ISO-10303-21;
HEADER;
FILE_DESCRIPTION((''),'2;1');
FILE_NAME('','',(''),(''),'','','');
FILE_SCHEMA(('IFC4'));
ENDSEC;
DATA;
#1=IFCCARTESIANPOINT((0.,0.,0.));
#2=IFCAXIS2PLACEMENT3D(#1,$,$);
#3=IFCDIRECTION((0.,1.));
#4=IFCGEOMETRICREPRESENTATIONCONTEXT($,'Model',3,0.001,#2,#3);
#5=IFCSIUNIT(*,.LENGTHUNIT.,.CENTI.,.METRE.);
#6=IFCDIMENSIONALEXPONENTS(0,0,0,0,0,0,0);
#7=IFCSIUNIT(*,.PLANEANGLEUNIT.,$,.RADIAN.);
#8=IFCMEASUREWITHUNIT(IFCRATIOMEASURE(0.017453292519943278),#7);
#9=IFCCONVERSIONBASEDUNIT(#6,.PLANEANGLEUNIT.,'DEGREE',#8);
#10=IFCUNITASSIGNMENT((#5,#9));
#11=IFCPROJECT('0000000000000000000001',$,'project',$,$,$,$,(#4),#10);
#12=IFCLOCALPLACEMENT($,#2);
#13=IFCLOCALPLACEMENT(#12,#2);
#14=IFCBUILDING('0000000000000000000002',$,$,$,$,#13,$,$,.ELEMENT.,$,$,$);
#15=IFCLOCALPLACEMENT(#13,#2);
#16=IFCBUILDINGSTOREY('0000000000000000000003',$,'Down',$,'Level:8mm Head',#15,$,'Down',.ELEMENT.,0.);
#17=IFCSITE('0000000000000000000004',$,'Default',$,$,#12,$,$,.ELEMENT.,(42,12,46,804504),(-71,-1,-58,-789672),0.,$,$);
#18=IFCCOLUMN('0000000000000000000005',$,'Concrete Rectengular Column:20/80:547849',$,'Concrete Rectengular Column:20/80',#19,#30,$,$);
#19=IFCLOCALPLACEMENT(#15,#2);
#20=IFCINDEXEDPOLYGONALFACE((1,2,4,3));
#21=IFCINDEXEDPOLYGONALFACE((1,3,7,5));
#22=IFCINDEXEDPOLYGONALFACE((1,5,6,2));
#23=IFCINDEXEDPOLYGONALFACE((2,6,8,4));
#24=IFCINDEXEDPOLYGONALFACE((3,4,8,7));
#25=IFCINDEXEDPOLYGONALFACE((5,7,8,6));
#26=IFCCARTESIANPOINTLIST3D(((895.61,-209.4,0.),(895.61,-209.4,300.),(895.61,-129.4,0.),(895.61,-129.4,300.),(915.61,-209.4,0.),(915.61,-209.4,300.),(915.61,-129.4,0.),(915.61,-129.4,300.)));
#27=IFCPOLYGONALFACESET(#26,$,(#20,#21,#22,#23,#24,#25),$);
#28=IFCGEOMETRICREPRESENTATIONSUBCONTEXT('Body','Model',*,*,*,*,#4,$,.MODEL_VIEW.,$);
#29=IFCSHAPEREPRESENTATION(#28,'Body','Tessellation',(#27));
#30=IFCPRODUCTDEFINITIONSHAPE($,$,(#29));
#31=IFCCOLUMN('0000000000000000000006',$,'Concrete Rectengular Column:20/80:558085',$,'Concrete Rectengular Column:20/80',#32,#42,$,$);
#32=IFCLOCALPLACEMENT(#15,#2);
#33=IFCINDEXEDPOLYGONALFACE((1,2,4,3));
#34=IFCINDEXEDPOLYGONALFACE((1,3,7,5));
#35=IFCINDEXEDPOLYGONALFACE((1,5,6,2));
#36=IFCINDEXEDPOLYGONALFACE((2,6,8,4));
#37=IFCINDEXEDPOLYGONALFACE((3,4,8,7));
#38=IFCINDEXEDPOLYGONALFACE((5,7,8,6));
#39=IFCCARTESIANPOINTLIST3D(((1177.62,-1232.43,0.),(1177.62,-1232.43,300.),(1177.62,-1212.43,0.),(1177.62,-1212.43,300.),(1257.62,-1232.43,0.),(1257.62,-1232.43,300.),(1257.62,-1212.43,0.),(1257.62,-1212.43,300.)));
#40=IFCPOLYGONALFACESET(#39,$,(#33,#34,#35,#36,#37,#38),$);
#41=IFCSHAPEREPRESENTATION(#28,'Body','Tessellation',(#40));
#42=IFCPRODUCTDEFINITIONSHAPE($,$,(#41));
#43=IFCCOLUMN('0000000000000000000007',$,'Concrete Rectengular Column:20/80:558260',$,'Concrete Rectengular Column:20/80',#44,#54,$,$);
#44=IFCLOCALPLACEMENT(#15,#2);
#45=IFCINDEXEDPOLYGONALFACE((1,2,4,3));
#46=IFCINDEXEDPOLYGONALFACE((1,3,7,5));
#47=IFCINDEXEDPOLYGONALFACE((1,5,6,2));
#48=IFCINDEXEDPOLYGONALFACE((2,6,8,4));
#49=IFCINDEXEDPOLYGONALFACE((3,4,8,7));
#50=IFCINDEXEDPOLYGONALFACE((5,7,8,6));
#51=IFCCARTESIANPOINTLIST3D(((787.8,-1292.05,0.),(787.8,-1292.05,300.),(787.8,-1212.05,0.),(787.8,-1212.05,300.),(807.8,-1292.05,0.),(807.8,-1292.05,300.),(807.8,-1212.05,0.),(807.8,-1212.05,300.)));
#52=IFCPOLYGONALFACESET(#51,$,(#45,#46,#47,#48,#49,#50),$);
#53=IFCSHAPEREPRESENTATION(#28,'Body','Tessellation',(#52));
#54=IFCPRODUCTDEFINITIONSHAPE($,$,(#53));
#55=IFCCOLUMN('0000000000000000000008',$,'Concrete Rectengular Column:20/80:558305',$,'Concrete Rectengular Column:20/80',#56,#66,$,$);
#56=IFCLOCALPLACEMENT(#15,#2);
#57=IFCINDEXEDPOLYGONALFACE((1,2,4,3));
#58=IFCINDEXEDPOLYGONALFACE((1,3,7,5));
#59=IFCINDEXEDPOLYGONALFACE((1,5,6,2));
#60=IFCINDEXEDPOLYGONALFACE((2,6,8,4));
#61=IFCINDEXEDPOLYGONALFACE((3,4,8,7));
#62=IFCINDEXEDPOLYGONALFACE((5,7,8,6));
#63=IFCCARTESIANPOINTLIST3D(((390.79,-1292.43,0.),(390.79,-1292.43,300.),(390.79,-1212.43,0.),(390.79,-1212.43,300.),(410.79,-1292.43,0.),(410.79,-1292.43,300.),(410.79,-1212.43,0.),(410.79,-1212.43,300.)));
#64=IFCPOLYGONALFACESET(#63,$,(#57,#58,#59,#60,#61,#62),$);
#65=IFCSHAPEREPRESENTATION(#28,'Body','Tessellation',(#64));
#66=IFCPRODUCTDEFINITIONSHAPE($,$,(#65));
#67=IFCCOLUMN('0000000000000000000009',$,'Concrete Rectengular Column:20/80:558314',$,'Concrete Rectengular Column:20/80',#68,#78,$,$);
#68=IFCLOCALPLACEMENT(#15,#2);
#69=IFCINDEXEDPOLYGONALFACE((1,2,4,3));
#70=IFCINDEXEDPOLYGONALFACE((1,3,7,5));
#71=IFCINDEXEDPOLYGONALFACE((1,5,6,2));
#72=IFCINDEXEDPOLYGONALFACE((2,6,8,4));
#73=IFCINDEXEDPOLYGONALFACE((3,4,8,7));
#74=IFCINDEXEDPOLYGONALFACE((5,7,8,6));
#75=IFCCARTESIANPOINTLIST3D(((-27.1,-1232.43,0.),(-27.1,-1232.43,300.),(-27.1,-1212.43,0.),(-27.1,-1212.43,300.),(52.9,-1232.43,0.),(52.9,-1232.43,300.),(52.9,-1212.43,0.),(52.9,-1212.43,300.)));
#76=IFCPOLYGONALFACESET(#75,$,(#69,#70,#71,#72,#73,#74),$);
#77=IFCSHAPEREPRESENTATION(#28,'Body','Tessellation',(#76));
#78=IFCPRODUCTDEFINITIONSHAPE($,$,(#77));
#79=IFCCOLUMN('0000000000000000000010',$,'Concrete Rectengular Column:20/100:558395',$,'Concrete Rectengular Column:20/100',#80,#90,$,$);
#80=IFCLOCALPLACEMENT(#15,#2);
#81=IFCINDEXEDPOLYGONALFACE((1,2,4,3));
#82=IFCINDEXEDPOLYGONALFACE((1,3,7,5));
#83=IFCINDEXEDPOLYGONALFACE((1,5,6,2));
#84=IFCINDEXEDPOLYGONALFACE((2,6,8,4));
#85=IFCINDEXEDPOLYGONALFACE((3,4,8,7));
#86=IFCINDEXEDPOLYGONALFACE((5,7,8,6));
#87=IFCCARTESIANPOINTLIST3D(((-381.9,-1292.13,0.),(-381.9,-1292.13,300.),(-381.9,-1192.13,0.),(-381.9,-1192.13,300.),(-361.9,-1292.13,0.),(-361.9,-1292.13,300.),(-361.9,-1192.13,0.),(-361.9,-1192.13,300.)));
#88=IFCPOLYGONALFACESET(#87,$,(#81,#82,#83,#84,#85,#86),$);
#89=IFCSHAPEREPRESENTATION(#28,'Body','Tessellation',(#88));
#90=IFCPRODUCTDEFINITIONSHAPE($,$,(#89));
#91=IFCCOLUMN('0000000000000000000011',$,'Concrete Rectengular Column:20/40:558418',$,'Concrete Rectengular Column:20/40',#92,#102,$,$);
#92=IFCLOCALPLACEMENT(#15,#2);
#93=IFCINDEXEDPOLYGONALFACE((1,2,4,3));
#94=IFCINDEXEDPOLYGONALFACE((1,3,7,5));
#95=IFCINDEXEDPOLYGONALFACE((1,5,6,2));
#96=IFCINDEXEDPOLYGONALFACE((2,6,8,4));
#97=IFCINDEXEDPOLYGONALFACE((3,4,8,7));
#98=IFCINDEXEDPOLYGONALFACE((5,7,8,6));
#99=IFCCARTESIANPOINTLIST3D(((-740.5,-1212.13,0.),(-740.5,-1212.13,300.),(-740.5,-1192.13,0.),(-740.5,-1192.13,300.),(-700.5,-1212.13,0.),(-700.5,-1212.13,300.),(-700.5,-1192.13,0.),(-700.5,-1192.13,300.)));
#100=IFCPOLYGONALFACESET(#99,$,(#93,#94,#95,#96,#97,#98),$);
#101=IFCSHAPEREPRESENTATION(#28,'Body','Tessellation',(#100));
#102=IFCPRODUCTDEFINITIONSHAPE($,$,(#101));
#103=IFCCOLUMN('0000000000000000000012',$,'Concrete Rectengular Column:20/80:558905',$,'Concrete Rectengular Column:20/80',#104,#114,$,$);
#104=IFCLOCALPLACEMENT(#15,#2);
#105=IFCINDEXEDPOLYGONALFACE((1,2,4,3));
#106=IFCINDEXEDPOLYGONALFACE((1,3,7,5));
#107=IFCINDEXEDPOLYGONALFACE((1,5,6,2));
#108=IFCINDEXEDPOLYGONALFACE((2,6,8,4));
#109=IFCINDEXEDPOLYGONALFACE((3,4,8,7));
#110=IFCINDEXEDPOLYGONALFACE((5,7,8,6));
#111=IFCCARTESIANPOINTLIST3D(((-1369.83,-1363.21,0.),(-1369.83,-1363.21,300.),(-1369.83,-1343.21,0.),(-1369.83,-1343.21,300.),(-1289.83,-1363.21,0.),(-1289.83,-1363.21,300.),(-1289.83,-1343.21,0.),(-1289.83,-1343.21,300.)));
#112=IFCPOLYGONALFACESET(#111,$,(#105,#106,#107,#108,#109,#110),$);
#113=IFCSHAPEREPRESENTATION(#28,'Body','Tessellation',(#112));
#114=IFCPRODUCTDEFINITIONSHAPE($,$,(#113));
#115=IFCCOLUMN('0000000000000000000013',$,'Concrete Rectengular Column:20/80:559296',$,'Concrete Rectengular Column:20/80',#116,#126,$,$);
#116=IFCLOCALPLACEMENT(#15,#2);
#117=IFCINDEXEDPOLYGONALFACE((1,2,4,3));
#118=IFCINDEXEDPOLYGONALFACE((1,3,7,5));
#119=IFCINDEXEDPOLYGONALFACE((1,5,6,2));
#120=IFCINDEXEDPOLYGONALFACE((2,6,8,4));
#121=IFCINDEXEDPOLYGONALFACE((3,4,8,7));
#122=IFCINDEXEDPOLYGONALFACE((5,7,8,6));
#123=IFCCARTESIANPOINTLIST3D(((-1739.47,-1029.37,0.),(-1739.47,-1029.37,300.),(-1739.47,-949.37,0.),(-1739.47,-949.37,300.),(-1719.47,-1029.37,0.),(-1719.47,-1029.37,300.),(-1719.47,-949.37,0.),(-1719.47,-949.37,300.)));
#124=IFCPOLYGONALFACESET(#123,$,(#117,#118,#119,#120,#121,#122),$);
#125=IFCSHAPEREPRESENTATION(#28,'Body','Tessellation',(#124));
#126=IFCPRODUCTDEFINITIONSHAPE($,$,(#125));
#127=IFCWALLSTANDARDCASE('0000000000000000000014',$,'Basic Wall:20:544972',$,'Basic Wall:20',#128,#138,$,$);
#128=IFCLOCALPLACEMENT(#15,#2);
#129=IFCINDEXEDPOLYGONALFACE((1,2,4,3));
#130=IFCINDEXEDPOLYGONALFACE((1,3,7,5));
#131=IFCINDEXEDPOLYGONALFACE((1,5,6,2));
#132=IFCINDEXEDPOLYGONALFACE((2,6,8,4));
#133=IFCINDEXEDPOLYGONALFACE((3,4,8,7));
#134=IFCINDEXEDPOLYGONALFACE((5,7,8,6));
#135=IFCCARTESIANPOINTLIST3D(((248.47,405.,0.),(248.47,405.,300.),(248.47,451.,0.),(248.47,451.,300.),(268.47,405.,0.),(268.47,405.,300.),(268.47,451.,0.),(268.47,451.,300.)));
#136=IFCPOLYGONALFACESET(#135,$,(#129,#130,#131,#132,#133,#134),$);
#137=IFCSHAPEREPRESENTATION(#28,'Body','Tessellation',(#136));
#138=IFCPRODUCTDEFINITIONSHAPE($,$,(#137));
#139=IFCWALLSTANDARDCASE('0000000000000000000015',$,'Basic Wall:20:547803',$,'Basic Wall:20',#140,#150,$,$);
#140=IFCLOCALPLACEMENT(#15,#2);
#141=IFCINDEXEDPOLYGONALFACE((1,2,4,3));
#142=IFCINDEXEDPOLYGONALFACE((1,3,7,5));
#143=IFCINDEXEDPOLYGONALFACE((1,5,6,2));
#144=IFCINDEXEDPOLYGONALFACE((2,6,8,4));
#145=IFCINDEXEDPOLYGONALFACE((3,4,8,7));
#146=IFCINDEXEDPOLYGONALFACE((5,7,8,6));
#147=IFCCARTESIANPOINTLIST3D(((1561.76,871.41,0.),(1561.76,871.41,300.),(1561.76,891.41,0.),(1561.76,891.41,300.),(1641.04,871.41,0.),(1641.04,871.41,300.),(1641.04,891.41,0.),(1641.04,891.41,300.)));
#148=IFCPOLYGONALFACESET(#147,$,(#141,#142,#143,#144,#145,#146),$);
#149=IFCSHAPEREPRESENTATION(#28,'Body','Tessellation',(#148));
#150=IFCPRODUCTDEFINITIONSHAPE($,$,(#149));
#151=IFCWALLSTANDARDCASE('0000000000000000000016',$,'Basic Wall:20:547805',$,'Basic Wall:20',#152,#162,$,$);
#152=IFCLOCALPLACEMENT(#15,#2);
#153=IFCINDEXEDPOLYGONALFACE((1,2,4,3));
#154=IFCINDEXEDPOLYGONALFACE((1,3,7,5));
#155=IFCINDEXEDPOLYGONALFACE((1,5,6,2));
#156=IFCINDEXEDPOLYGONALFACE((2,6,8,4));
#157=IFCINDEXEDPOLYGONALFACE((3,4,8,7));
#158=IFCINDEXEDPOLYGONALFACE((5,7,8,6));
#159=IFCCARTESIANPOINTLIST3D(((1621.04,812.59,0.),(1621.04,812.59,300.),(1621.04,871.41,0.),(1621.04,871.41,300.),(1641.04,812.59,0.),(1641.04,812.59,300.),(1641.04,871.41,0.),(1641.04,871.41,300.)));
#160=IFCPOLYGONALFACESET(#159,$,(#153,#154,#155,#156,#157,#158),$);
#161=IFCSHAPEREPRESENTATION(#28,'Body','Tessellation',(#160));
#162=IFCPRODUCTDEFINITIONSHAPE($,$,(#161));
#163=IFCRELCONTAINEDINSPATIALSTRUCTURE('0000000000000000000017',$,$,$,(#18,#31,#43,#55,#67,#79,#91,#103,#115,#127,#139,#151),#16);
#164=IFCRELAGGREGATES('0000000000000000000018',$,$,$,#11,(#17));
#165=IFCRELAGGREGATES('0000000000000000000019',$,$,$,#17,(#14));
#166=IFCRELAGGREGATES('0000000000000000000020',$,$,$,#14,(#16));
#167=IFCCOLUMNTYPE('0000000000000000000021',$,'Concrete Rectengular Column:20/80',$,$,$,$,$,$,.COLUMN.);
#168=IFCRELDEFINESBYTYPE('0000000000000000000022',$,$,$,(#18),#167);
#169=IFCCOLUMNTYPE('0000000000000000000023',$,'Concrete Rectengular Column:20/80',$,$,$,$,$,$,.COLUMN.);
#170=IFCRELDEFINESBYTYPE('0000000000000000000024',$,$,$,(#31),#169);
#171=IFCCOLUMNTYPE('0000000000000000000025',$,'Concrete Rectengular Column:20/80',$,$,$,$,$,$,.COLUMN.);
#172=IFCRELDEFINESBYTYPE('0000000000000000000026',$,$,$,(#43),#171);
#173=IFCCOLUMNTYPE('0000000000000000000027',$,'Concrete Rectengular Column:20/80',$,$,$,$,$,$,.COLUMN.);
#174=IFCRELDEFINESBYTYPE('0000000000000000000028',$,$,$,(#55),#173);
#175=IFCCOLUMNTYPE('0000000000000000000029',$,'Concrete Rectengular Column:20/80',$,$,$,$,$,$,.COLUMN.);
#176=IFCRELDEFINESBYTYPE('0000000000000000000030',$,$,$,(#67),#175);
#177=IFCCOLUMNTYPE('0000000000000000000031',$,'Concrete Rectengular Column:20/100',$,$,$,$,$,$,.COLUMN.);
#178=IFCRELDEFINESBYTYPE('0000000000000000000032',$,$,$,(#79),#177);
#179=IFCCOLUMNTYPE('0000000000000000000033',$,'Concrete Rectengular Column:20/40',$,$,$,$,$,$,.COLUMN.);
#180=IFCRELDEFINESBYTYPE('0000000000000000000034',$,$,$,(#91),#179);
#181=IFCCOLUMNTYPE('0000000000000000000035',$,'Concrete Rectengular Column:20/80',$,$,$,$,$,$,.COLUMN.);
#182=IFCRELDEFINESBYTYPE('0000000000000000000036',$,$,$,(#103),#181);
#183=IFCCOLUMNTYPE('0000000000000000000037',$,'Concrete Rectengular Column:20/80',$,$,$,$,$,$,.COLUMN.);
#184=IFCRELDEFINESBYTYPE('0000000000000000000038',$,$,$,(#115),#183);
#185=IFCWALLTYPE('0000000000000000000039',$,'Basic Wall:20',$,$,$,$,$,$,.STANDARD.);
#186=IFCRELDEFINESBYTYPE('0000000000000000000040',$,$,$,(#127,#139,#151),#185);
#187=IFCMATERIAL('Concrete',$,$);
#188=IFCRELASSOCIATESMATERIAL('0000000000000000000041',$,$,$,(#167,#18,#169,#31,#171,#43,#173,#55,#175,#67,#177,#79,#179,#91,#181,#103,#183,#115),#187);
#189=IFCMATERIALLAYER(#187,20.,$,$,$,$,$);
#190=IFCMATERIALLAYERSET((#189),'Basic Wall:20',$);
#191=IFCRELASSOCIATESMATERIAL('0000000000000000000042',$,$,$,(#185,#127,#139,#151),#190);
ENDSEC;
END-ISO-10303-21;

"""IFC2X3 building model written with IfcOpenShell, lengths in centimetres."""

from ifc_helpers import new_model, entity, si_unit, converted_unit, direction, frame, frame_2d, origin, origin_2d_with_axis, place, context, subcontext, project, spatial, rectangle, extrude, source, transform, mapped, material, layer, layer_set, layer_usage, type_object, type_shapes, element, save


model = new_model("IFC2X3")

# Units and contexts
model_context = context("Model", 3, precision=0.001, world=origin(), true_north=direction((0.0, 1.0)))
body_context = subcontext(model_context, "Body", "Model", "MODEL_VIEW")
ifc_project = project(units=[si_unit("LENGTHUNIT", "METRE", prefix="CENTI"), converted_unit("PLANEANGLEUNIT", "DEGREE", entity("IfcRatioMeasure", 0.017453292519943278), si_unit("PLANEANGLEUNIT", "RADIAN"), dimensions=[0, 0, 0, 0, 0, 0, 0])], contexts=[model_context])

# Site, building, storey
site_placement = place(None, origin())
site = spatial("IfcSite", under=ifc_project, at=site_placement, Name="Default", CompositionType="ELEMENT", RefLatitude=(42, 12, 46, 804504), RefLongitude=(-71, -1, -58, -789672), RefElevation=0.0)
building_placement = place(site_placement, origin())
building = spatial("IfcBuilding", under=site, at=building_placement, CompositionType="ELEMENT")
storey_placement = place(building_placement, origin())
storey = spatial("IfcBuildingStorey", under=building, at=storey_placement, Name="Down", ObjectType="Level:8mm Head", LongName="Down", CompositionType="ELEMENT", Elevation=0.0)

# Columns
ifc_material = material(Name="Concrete")
column_type_1 = type_object("IfcColumnType", Name="Concrete Rectengular Column:20/80", PredefinedType="COLUMN", material=ifc_material)
shared_shape_1 = source(origin(), body_context, "Body", "SweptSolid", [
    extrude(rectangle(XDim=80.0, YDim=20.0, at=origin_2d_with_axis()), frame((905.61, -169.4, 0.0), z_axis=(0.0, 0.0, 1.0), x_axis=(0.0, -1.0, 0.0)), (0.0, 0.0, 1.0), 300.0),
])
type_shapes(column_type_1, [shared_shape_1])
column_1_placement = place(storey_placement, origin())
element("IfcColumn", 1, at=column_1_placement, inside=storey, type_object=column_type_1, material=ifc_material, Name="Concrete Rectengular Column:20/80:547849", ObjectType="Concrete Rectengular Column:20/80", context=body_context, shape_type="MappedRepresentation", body=[
    mapped(shared_shape_1, transform((0.0, 0.0, 0.0), scale=1.0)),
])
column_type_2 = type_object("IfcColumnType", Name="Concrete Rectengular Column:20/80", PredefinedType="COLUMN", material=ifc_material)
shared_shape_2 = source(origin(), body_context, "Body", "SweptSolid", [
    extrude(rectangle(XDim=20.0, YDim=80.0, at=frame_2d((0.0, 0.0), x_axis=(1.0, 0.0))), frame((1217.62, -1222.43, 0.0), z_axis=(0.0, 0.0, 1.0), x_axis=(0.0, -1.0, 0.0)), (0.0, 0.0, 1.0), 300.0),
])
type_shapes(column_type_2, [shared_shape_2])
column_2_placement = place(storey_placement, origin())
element("IfcColumn", 2, at=column_2_placement, inside=storey, type_object=column_type_2, material=ifc_material, Name="Concrete Rectengular Column:20/80:558085", ObjectType="Concrete Rectengular Column:20/80", context=body_context, shape_type="MappedRepresentation", body=[
    mapped(shared_shape_2, transform((0.0, 0.0, 0.0), scale=1.0)),
])
column_type_3 = type_object("IfcColumnType", Name="Concrete Rectengular Column:20/80", PredefinedType="COLUMN", material=ifc_material)
shared_shape_3 = source(origin(), body_context, "Body", "SweptSolid", [
    extrude(rectangle(XDim=80.0, YDim=20.0, at=frame_2d((0.0, 0.0), x_axis=(1.0, 0.0))), frame((797.8, -1252.05, 0.0), z_axis=(0.0, 0.0, 1.0), x_axis=(0.0, -1.0, 0.0)), (0.0, 0.0, 1.0), 300.0),
])
type_shapes(column_type_3, [shared_shape_3])
column_3_placement = place(storey_placement, origin())
element("IfcColumn", 3, at=column_3_placement, inside=storey, type_object=column_type_3, material=ifc_material, Name="Concrete Rectengular Column:20/80:558260", ObjectType="Concrete Rectengular Column:20/80", context=body_context, shape_type="MappedRepresentation", body=[
    mapped(shared_shape_3, transform((0.0, 0.0, 0.0), scale=1.0)),
])
column_type_4 = type_object("IfcColumnType", Name="Concrete Rectengular Column:20/80", PredefinedType="COLUMN", material=ifc_material)
shared_shape_4 = source(origin(), body_context, "Body", "SweptSolid", [
    extrude(rectangle(XDim=80.0, YDim=20.0, at=origin_2d_with_axis()), frame((400.79, -1252.43, 0.0), z_axis=(0.0, 0.0, 1.0), x_axis=(0.0, -1.0, 0.0)), (0.0, 0.0, 1.0), 300.0),
])
type_shapes(column_type_4, [shared_shape_4])
column_4_placement = place(storey_placement, origin())
element("IfcColumn", 4, at=column_4_placement, inside=storey, type_object=column_type_4, material=ifc_material, Name="Concrete Rectengular Column:20/80:558305", ObjectType="Concrete Rectengular Column:20/80", context=body_context, shape_type="MappedRepresentation", body=[
    mapped(shared_shape_4, transform((0.0, 0.0, 0.0), scale=1.0)),
])
column_type_5 = type_object("IfcColumnType", Name="Concrete Rectengular Column:20/80", PredefinedType="COLUMN", material=ifc_material)
shared_shape_5 = source(origin(), body_context, "Body", "SweptSolid", [
    extrude(rectangle(XDim=20.0, YDim=80.0, at=frame_2d((0.0, 0.0), x_axis=(1.0, 0.0))), frame((12.9, -1222.43, 0.0), z_axis=(0.0, 0.0, 1.0), x_axis=(0.0, -1.0, 0.0)), (0.0, 0.0, 1.0), 300.0),
])
type_shapes(column_type_5, [shared_shape_5])
column_5_placement = place(storey_placement, origin())
element("IfcColumn", 5, at=column_5_placement, inside=storey, type_object=column_type_5, material=ifc_material, Name="Concrete Rectengular Column:20/80:558314", ObjectType="Concrete Rectengular Column:20/80", context=body_context, shape_type="MappedRepresentation", body=[
    mapped(shared_shape_5, transform((0.0, 0.0, 0.0), scale=1.0)),
])
column_type_6 = type_object("IfcColumnType", Name="Concrete Rectengular Column:20/100", PredefinedType="COLUMN", material=ifc_material)
shared_shape_6 = source(origin(), body_context, "Body", "SweptSolid", [
    extrude(rectangle(XDim=100.0, YDim=20.0, at=origin_2d_with_axis()), frame((-371.9, -1242.13, 0.0), z_axis=(0.0, 0.0, 1.0), x_axis=(0.0, -1.0, 0.0)), (0.0, 0.0, 1.0), 300.0),
])
type_shapes(column_type_6, [shared_shape_6])
column_6_placement = place(storey_placement, origin())
element("IfcColumn", 6, at=column_6_placement, inside=storey, type_object=column_type_6, material=ifc_material, Name="Concrete Rectengular Column:20/100:558395", ObjectType="Concrete Rectengular Column:20/100", context=body_context, shape_type="MappedRepresentation", body=[
    mapped(shared_shape_6, transform((0.0, 0.0, 0.0), scale=1.0)),
])
column_type_7 = type_object("IfcColumnType", Name="Concrete Rectengular Column:20/40", PredefinedType="COLUMN", material=ifc_material)
shared_shape_7 = source(origin(), body_context, "Body", "SweptSolid", [
    extrude(rectangle(XDim=20.0, YDim=40.0, at=frame_2d((0.0, 0.0), x_axis=(1.0, 0.0))), frame((-720.5, -1202.13, 0.0), z_axis=(0.0, 0.0, 1.0), x_axis=(0.0, -1.0, 0.0)), (0.0, 0.0, 1.0), 300.0),
])
type_shapes(column_type_7, [shared_shape_7])
column_7_placement = place(storey_placement, origin())
element("IfcColumn", 7, at=column_7_placement, inside=storey, type_object=column_type_7, material=ifc_material, Name="Concrete Rectengular Column:20/40:558418", ObjectType="Concrete Rectengular Column:20/40", context=body_context, shape_type="MappedRepresentation", body=[
    mapped(shared_shape_7, transform((0.0, 0.0, 0.0), scale=1.0)),
])
column_type_8 = type_object("IfcColumnType", Name="Concrete Rectengular Column:20/80", PredefinedType="COLUMN", material=ifc_material)
shared_shape_8 = source(origin(), body_context, "Body", "SweptSolid", [
    extrude(rectangle(XDim=20.0, YDim=80.0, at=frame_2d((0.0, 0.0), x_axis=(1.0, 0.0))), frame((-1329.83, -1353.21, 0.0), z_axis=(0.0, 0.0, 1.0), x_axis=(0.0, -1.0, 0.0)), (0.0, 0.0, 1.0), 300.0),
])
type_shapes(column_type_8, [shared_shape_8])
column_8_placement = place(storey_placement, origin())
element("IfcColumn", 8, at=column_8_placement, inside=storey, type_object=column_type_8, material=ifc_material, Name="Concrete Rectengular Column:20/80:558905", ObjectType="Concrete Rectengular Column:20/80", context=body_context, shape_type="MappedRepresentation", body=[
    mapped(shared_shape_8, transform((0.0, 0.0, 0.0), scale=1.0)),
])
column_type_9 = type_object("IfcColumnType", Name="Concrete Rectengular Column:20/80", PredefinedType="COLUMN", material=ifc_material)
shared_shape_9 = source(origin(), body_context, "Body", "SweptSolid", [
    extrude(rectangle(XDim=80.0, YDim=20.0, at=frame_2d((0.0, 0.0), x_axis=(1.0, 0.0))), frame((-1729.47, -989.37, 0.0), z_axis=(0.0, 0.0, 1.0), x_axis=(0.0, -1.0, 0.0)), (0.0, 0.0, 1.0), 300.0),
])
type_shapes(column_type_9, [shared_shape_9])
column_9_placement = place(storey_placement, origin())
element("IfcColumn", 9, at=column_9_placement, inside=storey, type_object=column_type_9, material=ifc_material, Name="Concrete Rectengular Column:20/80:559296", ObjectType="Concrete Rectengular Column:20/80", context=body_context, shape_type="MappedRepresentation", body=[
    mapped(shared_shape_9, transform((0.0, 0.0, 0.0), scale=1.0)),
])

# Walls
ifc_layer_1 = layer(ifc_material, 20.0)
ifc_layer_set_1 = layer_set([ifc_layer_1], Name="Basic Wall:20")
ifc_layer_usage_1 = layer_usage(ifc_layer_set_1, "AXIS2", "NEGATIVE", 10.0)
wall_type_1 = type_object("IfcWallType", Name="Basic Wall:20", PredefinedType="STANDARD", material=ifc_layer_set_1)
wall_1_placement = place(storey_placement, frame((258.47, 451.0, 0.0), z_axis=(0.0, 0.0, 1.0), x_axis=(0.0, -1.0, 0.0)))
element("IfcWallStandardCase", 10, at=wall_1_placement, inside=storey, type_object=wall_type_1, material=ifc_layer_usage_1, Name="Basic Wall:20:544972", ObjectType="Basic Wall:20", context=body_context, shape_type="SweptSolid", body=[
    extrude(rectangle(XDim=46.0, YDim=20.0, at=frame_2d((23.0, 0.0), x_axis=(-1.0, 0.0))), origin(), (0.0, 0.0, 1.0), 300.0),
])
ifc_layer_usage_2 = layer_usage(ifc_layer_set_1, "AXIS2", "NEGATIVE", 10.0)
wall_2_placement = place(storey_placement, frame((1561.76, 881.41, 0.0)))
element("IfcWallStandardCase", 11, at=wall_2_placement, inside=storey, type_object=wall_type_1, material=ifc_layer_usage_2, Name="Basic Wall:20:547803", ObjectType="Basic Wall:20", context=body_context, shape_type="SweptSolid", body=[
    extrude(rectangle(XDim=79.28, YDim=20.0, at=frame_2d((39.64, 0.0), x_axis=(-1.0, 0.0))), origin(), (0.0, 0.0, 1.0), 300.0),
])
ifc_layer_usage_3 = layer_usage(ifc_layer_set_1, "AXIS2", "NEGATIVE", 10.0)
wall_3_placement = place(storey_placement, frame((1631.04, 871.41, 0.0), z_axis=(0.0, 0.0, 1.0), x_axis=(0.0, -1.0, 0.0)))
element("IfcWallStandardCase", 12, at=wall_3_placement, inside=storey, type_object=wall_type_1, material=ifc_layer_usage_3, Name="Basic Wall:20:547805", ObjectType="Basic Wall:20", context=body_context, shape_type="SweptSolid", body=[
    extrude(rectangle(XDim=58.82, YDim=20.0, at=frame_2d((29.41, 0.0), x_axis=(-1.0, 0.0))), origin(), (0.0, 0.0, 1.0), 300.0),
])

save(model, "model.ifc")
